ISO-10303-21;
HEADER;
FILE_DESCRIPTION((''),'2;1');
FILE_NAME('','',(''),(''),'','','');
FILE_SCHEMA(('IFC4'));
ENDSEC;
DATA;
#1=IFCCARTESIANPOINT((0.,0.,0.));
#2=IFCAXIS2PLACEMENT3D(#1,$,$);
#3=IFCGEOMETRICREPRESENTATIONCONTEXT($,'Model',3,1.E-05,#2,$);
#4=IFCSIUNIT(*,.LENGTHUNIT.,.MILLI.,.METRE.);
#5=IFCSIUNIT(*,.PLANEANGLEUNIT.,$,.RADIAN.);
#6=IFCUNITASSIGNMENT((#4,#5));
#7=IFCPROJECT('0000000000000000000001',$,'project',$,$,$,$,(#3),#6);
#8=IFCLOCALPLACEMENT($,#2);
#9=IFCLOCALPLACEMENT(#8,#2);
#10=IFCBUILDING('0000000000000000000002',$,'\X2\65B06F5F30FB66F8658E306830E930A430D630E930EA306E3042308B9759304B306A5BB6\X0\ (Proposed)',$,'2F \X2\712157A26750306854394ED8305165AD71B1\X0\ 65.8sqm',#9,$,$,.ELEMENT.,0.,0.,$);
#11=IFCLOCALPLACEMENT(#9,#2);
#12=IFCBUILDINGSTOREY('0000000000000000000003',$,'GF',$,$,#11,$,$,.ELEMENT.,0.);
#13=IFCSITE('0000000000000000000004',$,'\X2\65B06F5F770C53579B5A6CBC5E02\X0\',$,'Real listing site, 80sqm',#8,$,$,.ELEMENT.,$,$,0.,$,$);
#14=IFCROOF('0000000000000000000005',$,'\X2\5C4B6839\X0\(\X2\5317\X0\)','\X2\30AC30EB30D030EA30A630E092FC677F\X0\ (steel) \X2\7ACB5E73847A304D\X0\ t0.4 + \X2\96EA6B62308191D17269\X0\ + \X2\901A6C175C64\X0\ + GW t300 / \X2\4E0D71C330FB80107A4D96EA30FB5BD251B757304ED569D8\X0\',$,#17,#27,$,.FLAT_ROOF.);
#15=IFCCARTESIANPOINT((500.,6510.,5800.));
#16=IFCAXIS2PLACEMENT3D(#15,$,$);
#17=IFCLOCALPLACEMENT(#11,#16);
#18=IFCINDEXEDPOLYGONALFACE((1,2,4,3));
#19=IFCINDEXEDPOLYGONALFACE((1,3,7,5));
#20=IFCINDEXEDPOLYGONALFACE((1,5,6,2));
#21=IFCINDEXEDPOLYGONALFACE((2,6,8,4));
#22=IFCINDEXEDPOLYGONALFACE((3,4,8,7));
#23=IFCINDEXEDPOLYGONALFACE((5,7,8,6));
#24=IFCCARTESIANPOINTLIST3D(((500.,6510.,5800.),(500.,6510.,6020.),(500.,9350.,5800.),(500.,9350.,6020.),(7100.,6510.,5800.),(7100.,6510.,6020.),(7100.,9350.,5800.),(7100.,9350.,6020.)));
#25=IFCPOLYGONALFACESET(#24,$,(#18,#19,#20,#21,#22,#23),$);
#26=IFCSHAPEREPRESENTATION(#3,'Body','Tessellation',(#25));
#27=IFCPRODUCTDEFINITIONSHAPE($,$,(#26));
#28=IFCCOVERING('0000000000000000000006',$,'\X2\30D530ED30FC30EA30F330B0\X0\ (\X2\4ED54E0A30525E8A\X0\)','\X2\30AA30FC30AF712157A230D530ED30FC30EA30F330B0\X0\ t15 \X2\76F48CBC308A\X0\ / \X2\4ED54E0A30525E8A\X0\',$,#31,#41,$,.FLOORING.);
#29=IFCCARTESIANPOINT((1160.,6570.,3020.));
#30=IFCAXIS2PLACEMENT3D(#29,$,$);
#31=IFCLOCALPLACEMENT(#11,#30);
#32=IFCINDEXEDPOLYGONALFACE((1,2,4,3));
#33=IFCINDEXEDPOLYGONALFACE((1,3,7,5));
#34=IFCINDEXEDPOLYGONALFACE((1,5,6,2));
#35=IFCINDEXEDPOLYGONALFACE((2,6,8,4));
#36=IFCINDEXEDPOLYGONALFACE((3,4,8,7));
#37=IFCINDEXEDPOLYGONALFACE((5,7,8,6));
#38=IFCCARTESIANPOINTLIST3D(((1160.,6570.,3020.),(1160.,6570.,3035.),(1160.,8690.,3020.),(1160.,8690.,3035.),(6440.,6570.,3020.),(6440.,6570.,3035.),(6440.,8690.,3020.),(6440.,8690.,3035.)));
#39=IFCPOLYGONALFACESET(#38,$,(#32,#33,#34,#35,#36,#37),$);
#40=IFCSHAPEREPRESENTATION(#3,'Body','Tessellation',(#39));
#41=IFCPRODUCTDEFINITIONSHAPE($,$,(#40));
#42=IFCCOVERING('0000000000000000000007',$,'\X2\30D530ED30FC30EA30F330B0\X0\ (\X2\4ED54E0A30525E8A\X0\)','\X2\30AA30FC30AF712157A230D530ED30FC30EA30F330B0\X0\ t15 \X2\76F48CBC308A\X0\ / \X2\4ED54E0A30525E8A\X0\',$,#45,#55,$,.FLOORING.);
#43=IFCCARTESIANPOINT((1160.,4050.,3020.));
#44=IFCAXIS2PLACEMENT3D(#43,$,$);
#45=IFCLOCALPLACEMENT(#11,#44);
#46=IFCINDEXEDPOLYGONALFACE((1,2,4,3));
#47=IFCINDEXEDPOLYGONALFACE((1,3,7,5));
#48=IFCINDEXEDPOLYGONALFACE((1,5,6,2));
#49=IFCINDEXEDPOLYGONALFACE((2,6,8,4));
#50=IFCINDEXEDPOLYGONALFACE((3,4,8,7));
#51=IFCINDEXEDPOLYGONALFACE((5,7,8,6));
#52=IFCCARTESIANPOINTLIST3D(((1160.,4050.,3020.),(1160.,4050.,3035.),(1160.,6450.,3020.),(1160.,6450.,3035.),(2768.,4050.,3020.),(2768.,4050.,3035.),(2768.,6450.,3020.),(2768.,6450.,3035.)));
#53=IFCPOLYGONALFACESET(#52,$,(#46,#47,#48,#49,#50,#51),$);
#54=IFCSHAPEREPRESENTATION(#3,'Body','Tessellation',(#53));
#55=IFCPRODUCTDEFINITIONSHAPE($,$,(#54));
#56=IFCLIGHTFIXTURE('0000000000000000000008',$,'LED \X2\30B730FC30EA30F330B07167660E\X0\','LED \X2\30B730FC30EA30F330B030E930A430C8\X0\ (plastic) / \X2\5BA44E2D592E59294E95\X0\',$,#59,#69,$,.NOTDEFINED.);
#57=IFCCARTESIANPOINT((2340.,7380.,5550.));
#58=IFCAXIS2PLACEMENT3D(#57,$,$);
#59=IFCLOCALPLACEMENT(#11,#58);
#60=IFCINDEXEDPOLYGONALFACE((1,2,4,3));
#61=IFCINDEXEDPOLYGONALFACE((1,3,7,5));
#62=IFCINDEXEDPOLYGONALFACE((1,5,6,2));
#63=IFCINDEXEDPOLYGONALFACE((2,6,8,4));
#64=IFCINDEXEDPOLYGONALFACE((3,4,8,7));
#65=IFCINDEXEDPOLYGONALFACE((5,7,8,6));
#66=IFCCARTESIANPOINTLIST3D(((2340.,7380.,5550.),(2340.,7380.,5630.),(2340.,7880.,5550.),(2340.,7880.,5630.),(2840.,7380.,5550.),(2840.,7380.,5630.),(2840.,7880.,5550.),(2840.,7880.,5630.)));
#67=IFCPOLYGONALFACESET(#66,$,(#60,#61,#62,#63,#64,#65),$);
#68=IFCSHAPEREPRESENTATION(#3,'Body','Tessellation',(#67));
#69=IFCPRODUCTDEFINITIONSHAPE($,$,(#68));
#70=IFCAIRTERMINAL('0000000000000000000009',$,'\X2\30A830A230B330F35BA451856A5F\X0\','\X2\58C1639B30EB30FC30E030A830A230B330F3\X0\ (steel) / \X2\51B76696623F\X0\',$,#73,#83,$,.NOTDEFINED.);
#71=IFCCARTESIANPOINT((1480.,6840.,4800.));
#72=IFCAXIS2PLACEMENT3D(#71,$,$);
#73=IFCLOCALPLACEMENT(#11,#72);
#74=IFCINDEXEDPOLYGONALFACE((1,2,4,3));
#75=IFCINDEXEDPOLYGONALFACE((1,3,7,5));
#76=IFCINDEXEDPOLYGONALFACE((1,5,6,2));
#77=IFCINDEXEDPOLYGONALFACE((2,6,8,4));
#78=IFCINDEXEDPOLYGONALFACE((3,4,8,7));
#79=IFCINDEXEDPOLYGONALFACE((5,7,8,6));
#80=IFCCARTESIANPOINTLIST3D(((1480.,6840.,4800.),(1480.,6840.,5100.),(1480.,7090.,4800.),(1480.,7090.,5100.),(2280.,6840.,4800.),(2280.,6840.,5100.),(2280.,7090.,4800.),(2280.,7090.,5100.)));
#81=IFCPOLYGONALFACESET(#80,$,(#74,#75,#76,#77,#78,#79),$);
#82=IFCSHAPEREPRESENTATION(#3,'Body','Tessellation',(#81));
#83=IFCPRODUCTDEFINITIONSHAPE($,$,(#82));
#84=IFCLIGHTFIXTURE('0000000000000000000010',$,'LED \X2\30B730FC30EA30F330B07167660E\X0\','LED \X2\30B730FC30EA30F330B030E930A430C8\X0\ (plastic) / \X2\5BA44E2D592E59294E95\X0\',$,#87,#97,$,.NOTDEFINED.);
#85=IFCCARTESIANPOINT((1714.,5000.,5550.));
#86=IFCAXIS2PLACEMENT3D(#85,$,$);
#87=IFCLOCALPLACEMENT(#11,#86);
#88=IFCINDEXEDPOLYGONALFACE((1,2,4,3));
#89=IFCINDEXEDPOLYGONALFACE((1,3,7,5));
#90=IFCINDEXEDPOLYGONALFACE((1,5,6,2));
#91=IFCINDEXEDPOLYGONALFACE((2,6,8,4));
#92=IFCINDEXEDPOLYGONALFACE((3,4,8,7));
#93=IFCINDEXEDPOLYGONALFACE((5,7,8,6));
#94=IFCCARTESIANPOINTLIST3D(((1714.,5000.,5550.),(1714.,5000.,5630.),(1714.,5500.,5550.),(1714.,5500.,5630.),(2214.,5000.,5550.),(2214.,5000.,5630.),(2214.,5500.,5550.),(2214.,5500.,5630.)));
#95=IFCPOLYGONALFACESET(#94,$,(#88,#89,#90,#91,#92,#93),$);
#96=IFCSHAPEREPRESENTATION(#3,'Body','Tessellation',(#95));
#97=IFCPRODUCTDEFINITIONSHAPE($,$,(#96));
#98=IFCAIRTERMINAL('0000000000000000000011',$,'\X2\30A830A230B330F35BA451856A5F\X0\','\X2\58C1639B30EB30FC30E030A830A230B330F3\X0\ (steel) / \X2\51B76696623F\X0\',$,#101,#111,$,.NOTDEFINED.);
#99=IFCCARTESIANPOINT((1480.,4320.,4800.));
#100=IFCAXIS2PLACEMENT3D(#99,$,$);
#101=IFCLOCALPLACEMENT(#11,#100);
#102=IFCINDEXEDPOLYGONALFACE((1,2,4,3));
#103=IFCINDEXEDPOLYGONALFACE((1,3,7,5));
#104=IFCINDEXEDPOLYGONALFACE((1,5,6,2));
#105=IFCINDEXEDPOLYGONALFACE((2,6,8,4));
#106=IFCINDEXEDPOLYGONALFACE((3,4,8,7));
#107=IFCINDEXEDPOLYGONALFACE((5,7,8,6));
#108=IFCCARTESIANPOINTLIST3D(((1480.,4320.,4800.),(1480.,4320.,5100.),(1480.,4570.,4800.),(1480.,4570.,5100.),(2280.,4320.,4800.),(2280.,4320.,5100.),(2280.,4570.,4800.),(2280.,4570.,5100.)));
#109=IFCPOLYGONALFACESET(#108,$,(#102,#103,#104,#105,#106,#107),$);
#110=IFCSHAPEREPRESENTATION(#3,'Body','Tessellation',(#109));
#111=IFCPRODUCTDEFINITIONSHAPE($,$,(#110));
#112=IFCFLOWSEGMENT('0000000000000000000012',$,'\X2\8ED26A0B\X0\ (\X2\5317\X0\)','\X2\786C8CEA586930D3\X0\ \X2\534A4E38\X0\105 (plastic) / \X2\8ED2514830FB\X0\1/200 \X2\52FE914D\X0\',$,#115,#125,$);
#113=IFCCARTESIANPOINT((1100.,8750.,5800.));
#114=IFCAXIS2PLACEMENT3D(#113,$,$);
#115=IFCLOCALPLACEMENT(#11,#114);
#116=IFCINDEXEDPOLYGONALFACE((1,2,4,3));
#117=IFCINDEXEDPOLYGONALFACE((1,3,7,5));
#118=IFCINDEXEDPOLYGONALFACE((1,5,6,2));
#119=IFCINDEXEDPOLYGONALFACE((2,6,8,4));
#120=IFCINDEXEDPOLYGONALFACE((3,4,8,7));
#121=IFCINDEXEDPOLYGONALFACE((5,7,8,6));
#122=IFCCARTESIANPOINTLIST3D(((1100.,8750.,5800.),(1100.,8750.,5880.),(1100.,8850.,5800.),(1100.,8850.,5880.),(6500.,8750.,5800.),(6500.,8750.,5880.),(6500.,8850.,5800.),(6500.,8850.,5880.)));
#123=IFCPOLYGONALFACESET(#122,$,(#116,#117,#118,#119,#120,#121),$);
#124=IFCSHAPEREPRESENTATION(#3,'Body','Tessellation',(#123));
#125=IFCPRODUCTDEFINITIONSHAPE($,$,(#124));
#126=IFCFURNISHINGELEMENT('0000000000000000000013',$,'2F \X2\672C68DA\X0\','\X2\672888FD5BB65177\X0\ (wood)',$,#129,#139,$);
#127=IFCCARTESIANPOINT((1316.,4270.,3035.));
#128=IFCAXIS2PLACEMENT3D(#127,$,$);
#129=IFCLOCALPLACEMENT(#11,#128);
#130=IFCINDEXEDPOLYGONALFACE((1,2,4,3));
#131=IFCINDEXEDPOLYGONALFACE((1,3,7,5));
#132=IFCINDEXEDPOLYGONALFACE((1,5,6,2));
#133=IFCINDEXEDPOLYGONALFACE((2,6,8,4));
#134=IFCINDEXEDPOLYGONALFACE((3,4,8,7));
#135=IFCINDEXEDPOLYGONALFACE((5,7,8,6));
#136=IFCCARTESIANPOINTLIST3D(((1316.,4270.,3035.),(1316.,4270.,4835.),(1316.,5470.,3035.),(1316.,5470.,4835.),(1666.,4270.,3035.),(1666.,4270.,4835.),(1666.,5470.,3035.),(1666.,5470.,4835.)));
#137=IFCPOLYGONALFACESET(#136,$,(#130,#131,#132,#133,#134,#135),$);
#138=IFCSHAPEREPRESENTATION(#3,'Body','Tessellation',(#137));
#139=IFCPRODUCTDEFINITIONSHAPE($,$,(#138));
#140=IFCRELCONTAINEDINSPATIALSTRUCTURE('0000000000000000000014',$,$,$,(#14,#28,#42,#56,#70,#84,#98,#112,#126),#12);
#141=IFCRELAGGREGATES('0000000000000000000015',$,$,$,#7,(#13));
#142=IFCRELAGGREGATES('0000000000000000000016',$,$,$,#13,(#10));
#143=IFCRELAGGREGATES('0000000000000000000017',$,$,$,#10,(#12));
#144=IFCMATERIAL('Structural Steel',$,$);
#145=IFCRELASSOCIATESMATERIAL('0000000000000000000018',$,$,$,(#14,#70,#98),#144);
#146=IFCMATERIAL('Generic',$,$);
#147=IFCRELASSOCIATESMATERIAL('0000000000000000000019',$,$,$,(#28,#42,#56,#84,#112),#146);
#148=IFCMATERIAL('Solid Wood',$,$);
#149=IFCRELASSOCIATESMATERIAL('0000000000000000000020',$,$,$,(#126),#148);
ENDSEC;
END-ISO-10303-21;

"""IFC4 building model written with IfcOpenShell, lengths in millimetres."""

from ifc_helpers import new_model, si_unit, frame, frame_2d, origin, place, context, project, spatial, rectangle, extrude, material, element, save


model = new_model("IFC4")

# Units and contexts
model_context = context("Model", 3, precision=1e-05, world=origin())
ifc_project = project(units=[si_unit("LENGTHUNIT", "METRE", prefix="MILLI"), si_unit("PLANEANGLEUNIT", "RADIAN")], contexts=[model_context])

# Site, building, storey
site_placement = place(None, origin())
site = spatial("IfcSite", under=ifc_project, at=site_placement, Name="新潟県南魚沼市", ObjectType="Real listing site, 80sqm", CompositionType="ELEMENT", RefElevation=0.0)
building_placement = place(site_placement, origin())
building = spatial("IfcBuilding", under=site, at=building_placement, Name="新潟・書斎とライブラリのある静かな家 (Proposed)", ObjectType="2F 無垢材と吹付け断熱 65.8sqm", CompositionType="ELEMENT", ElevationOfRefHeight=0.0, ElevationOfTerrain=0.0)
storey_placement = place(building_placement, origin())
storey = spatial("IfcBuildingStorey", under=building, at=storey_placement, Name="GF", CompositionType="ELEMENT", Elevation=0.0)

# Shared definitions
ifc_material_1 = material(Name="Solid Wood")

# Roof
ifc_material_2 = material(Name="Structural Steel")
for number, where, name in (
    (1, (500.0, 6510.0, 5800.0), "屋根(北)"),
):
    element("IfcRoof", number, at=place(storey_placement, frame(where)), inside=storey, material=ifc_material_2, Name=name, Description="ガルバリウム鋼板 (steel) 立平葺き t0.4 + 雪止め金物 + 通気層 + GW t300 / 不燃・耐積雪・寒冷地仕様", PredefinedType="FLAT_ROOF", context=model_context, shape_type="SweptSolid", body=[
        extrude(rectangle(XDim=6600.0, YDim=2840.0, at=frame_2d((3300.0, 1420.0))), frame((500.0, 6510.0, 5800.0)), (0.0, 0.0, 1.0), 220.0),
    ])

# Coverings
ifc_material_3 = material(Name="Generic")
covering_1_placement = place(storey_placement, frame((1160.0, 6570.0, 3020.0)))
element("IfcCovering", 2, at=covering_1_placement, inside=storey, material=ifc_material_3, Name="フローリング (仕上げ床)", Description="オーク無垢フローリング t15 直貼り / 仕上げ床", PredefinedType="FLOORING", context=model_context, shape_type="SweptSolid", body=[
    extrude(rectangle(XDim=5280.0, YDim=2120.0, at=frame_2d((2640.0, 1060.0))), frame((1160.0, 6570.0, 3020.0)), (0.0, 0.0, 1.0), 15.0),
])
covering_2_placement = place(storey_placement, frame((1160.0, 4050.0, 3020.0)))
element("IfcCovering", 3, at=covering_2_placement, inside=storey, material=ifc_material_3, Name="フローリング (仕上げ床)", Description="オーク無垢フローリング t15 直貼り / 仕上げ床", PredefinedType="FLOORING", context=model_context, shape_type="SweptSolid", body=[
    extrude(rectangle(XDim=1608.0, YDim=2400.0, at=frame_2d((804.0, 1200.0))), frame((1160.0, 4050.0, 3020.0)), (0.0, 0.0, 1.0), 15.0),
])

# Light fixture
light_fixture_1_placement = place(storey_placement, frame((2340.0, 7380.0, 5550.0)))
element("IfcLightFixture", 4, at=light_fixture_1_placement, inside=storey, material=ifc_material_3, Name="LED シーリング照明", Description="LED シーリングライト (plastic) / 室中央天井", PredefinedType="NOTDEFINED", context=model_context, shape_type="SweptSolid", body=[
    extrude(rectangle(XDim=500.0, YDim=500.0, at=frame_2d((250.0, 250.0))), frame((2340.0, 7380.0, 5550.0)), (0.0, 0.0, 1.0), 80.0),
])

# Air terminal
air_terminal_1_placement = place(storey_placement, frame((1480.0, 6840.0, 4800.0)))
element("IfcAirTerminal", 5, at=air_terminal_1_placement, inside=storey, material=ifc_material_2, Name="エアコン室内機", Description="壁掛ルームエアコン (steel) / 冷暖房", PredefinedType="NOTDEFINED", context=model_context, shape_type="SweptSolid", body=[
    extrude(rectangle(XDim=800.0, YDim=250.0, at=frame_2d((400.0, 125.0))), frame((1480.0, 6840.0, 4800.0)), (0.0, 0.0, 1.0), 300.0),
])

# Light fixture
light_fixture_2_placement = place(storey_placement, frame((1714.0, 5000.0, 5550.0)))
element("IfcLightFixture", 6, at=light_fixture_2_placement, inside=storey, material=ifc_material_3, Name="LED シーリング照明", Description="LED シーリングライト (plastic) / 室中央天井", PredefinedType="NOTDEFINED", context=model_context, shape_type="SweptSolid", body=[
    extrude(rectangle(XDim=500.0, YDim=500.0, at=frame_2d((250.0, 250.0))), frame((1714.0, 5000.0, 5550.0)), (0.0, 0.0, 1.0), 80.0),
])

# Air terminal
air_terminal_2_placement = place(storey_placement, frame((1480.0, 4320.0, 4800.0)))
element("IfcAirTerminal", 7, at=air_terminal_2_placement, inside=storey, material=ifc_material_2, Name="エアコン室内機", Description="壁掛ルームエアコン (steel) / 冷暖房", PredefinedType="NOTDEFINED", context=model_context, shape_type="SweptSolid", body=[
    extrude(rectangle(XDim=800.0, YDim=250.0, at=frame_2d((400.0, 125.0))), frame((1480.0, 4320.0, 4800.0)), (0.0, 0.0, 1.0), 300.0),
])

# Flow segment
flow_segment_placement = place(storey_placement, frame((1100.0, 8750.0, 5800.0)))
element("IfcFlowSegment", 8, at=flow_segment_placement, inside=storey, material=ifc_material_3, Name="軒樋 (北)", Description="硬質塩ビ 半丸105 (plastic) / 軒先・1/200 勾配", context=model_context, shape_type="SweptSolid", body=[
    extrude(rectangle(XDim=5400.0, YDim=100.0, at=frame_2d((2700.0, 50.0))), frame((1100.0, 8750.0, 5800.0)), (0.0, 0.0, 1.0), 80.0),
])

# Furnishing element
furnishing_placement = place(storey_placement, frame((1316.0, 4270.0, 3035.0)))
element("IfcFurnishingElement", 9, at=furnishing_placement, inside=storey, material=ifc_material_1, Name="2F 本棚", Description="木製家具 (wood)", context=model_context, shape_type="SweptSolid", body=[
    extrude(rectangle(XDim=350.0, YDim=1200.0, at=frame_2d((175.0, 600.0))), frame((1316.0, 4270.0, 3035.0)), (0.0, 0.0, 1.0), 1800.0),
])

save(model, "model.ifc")
